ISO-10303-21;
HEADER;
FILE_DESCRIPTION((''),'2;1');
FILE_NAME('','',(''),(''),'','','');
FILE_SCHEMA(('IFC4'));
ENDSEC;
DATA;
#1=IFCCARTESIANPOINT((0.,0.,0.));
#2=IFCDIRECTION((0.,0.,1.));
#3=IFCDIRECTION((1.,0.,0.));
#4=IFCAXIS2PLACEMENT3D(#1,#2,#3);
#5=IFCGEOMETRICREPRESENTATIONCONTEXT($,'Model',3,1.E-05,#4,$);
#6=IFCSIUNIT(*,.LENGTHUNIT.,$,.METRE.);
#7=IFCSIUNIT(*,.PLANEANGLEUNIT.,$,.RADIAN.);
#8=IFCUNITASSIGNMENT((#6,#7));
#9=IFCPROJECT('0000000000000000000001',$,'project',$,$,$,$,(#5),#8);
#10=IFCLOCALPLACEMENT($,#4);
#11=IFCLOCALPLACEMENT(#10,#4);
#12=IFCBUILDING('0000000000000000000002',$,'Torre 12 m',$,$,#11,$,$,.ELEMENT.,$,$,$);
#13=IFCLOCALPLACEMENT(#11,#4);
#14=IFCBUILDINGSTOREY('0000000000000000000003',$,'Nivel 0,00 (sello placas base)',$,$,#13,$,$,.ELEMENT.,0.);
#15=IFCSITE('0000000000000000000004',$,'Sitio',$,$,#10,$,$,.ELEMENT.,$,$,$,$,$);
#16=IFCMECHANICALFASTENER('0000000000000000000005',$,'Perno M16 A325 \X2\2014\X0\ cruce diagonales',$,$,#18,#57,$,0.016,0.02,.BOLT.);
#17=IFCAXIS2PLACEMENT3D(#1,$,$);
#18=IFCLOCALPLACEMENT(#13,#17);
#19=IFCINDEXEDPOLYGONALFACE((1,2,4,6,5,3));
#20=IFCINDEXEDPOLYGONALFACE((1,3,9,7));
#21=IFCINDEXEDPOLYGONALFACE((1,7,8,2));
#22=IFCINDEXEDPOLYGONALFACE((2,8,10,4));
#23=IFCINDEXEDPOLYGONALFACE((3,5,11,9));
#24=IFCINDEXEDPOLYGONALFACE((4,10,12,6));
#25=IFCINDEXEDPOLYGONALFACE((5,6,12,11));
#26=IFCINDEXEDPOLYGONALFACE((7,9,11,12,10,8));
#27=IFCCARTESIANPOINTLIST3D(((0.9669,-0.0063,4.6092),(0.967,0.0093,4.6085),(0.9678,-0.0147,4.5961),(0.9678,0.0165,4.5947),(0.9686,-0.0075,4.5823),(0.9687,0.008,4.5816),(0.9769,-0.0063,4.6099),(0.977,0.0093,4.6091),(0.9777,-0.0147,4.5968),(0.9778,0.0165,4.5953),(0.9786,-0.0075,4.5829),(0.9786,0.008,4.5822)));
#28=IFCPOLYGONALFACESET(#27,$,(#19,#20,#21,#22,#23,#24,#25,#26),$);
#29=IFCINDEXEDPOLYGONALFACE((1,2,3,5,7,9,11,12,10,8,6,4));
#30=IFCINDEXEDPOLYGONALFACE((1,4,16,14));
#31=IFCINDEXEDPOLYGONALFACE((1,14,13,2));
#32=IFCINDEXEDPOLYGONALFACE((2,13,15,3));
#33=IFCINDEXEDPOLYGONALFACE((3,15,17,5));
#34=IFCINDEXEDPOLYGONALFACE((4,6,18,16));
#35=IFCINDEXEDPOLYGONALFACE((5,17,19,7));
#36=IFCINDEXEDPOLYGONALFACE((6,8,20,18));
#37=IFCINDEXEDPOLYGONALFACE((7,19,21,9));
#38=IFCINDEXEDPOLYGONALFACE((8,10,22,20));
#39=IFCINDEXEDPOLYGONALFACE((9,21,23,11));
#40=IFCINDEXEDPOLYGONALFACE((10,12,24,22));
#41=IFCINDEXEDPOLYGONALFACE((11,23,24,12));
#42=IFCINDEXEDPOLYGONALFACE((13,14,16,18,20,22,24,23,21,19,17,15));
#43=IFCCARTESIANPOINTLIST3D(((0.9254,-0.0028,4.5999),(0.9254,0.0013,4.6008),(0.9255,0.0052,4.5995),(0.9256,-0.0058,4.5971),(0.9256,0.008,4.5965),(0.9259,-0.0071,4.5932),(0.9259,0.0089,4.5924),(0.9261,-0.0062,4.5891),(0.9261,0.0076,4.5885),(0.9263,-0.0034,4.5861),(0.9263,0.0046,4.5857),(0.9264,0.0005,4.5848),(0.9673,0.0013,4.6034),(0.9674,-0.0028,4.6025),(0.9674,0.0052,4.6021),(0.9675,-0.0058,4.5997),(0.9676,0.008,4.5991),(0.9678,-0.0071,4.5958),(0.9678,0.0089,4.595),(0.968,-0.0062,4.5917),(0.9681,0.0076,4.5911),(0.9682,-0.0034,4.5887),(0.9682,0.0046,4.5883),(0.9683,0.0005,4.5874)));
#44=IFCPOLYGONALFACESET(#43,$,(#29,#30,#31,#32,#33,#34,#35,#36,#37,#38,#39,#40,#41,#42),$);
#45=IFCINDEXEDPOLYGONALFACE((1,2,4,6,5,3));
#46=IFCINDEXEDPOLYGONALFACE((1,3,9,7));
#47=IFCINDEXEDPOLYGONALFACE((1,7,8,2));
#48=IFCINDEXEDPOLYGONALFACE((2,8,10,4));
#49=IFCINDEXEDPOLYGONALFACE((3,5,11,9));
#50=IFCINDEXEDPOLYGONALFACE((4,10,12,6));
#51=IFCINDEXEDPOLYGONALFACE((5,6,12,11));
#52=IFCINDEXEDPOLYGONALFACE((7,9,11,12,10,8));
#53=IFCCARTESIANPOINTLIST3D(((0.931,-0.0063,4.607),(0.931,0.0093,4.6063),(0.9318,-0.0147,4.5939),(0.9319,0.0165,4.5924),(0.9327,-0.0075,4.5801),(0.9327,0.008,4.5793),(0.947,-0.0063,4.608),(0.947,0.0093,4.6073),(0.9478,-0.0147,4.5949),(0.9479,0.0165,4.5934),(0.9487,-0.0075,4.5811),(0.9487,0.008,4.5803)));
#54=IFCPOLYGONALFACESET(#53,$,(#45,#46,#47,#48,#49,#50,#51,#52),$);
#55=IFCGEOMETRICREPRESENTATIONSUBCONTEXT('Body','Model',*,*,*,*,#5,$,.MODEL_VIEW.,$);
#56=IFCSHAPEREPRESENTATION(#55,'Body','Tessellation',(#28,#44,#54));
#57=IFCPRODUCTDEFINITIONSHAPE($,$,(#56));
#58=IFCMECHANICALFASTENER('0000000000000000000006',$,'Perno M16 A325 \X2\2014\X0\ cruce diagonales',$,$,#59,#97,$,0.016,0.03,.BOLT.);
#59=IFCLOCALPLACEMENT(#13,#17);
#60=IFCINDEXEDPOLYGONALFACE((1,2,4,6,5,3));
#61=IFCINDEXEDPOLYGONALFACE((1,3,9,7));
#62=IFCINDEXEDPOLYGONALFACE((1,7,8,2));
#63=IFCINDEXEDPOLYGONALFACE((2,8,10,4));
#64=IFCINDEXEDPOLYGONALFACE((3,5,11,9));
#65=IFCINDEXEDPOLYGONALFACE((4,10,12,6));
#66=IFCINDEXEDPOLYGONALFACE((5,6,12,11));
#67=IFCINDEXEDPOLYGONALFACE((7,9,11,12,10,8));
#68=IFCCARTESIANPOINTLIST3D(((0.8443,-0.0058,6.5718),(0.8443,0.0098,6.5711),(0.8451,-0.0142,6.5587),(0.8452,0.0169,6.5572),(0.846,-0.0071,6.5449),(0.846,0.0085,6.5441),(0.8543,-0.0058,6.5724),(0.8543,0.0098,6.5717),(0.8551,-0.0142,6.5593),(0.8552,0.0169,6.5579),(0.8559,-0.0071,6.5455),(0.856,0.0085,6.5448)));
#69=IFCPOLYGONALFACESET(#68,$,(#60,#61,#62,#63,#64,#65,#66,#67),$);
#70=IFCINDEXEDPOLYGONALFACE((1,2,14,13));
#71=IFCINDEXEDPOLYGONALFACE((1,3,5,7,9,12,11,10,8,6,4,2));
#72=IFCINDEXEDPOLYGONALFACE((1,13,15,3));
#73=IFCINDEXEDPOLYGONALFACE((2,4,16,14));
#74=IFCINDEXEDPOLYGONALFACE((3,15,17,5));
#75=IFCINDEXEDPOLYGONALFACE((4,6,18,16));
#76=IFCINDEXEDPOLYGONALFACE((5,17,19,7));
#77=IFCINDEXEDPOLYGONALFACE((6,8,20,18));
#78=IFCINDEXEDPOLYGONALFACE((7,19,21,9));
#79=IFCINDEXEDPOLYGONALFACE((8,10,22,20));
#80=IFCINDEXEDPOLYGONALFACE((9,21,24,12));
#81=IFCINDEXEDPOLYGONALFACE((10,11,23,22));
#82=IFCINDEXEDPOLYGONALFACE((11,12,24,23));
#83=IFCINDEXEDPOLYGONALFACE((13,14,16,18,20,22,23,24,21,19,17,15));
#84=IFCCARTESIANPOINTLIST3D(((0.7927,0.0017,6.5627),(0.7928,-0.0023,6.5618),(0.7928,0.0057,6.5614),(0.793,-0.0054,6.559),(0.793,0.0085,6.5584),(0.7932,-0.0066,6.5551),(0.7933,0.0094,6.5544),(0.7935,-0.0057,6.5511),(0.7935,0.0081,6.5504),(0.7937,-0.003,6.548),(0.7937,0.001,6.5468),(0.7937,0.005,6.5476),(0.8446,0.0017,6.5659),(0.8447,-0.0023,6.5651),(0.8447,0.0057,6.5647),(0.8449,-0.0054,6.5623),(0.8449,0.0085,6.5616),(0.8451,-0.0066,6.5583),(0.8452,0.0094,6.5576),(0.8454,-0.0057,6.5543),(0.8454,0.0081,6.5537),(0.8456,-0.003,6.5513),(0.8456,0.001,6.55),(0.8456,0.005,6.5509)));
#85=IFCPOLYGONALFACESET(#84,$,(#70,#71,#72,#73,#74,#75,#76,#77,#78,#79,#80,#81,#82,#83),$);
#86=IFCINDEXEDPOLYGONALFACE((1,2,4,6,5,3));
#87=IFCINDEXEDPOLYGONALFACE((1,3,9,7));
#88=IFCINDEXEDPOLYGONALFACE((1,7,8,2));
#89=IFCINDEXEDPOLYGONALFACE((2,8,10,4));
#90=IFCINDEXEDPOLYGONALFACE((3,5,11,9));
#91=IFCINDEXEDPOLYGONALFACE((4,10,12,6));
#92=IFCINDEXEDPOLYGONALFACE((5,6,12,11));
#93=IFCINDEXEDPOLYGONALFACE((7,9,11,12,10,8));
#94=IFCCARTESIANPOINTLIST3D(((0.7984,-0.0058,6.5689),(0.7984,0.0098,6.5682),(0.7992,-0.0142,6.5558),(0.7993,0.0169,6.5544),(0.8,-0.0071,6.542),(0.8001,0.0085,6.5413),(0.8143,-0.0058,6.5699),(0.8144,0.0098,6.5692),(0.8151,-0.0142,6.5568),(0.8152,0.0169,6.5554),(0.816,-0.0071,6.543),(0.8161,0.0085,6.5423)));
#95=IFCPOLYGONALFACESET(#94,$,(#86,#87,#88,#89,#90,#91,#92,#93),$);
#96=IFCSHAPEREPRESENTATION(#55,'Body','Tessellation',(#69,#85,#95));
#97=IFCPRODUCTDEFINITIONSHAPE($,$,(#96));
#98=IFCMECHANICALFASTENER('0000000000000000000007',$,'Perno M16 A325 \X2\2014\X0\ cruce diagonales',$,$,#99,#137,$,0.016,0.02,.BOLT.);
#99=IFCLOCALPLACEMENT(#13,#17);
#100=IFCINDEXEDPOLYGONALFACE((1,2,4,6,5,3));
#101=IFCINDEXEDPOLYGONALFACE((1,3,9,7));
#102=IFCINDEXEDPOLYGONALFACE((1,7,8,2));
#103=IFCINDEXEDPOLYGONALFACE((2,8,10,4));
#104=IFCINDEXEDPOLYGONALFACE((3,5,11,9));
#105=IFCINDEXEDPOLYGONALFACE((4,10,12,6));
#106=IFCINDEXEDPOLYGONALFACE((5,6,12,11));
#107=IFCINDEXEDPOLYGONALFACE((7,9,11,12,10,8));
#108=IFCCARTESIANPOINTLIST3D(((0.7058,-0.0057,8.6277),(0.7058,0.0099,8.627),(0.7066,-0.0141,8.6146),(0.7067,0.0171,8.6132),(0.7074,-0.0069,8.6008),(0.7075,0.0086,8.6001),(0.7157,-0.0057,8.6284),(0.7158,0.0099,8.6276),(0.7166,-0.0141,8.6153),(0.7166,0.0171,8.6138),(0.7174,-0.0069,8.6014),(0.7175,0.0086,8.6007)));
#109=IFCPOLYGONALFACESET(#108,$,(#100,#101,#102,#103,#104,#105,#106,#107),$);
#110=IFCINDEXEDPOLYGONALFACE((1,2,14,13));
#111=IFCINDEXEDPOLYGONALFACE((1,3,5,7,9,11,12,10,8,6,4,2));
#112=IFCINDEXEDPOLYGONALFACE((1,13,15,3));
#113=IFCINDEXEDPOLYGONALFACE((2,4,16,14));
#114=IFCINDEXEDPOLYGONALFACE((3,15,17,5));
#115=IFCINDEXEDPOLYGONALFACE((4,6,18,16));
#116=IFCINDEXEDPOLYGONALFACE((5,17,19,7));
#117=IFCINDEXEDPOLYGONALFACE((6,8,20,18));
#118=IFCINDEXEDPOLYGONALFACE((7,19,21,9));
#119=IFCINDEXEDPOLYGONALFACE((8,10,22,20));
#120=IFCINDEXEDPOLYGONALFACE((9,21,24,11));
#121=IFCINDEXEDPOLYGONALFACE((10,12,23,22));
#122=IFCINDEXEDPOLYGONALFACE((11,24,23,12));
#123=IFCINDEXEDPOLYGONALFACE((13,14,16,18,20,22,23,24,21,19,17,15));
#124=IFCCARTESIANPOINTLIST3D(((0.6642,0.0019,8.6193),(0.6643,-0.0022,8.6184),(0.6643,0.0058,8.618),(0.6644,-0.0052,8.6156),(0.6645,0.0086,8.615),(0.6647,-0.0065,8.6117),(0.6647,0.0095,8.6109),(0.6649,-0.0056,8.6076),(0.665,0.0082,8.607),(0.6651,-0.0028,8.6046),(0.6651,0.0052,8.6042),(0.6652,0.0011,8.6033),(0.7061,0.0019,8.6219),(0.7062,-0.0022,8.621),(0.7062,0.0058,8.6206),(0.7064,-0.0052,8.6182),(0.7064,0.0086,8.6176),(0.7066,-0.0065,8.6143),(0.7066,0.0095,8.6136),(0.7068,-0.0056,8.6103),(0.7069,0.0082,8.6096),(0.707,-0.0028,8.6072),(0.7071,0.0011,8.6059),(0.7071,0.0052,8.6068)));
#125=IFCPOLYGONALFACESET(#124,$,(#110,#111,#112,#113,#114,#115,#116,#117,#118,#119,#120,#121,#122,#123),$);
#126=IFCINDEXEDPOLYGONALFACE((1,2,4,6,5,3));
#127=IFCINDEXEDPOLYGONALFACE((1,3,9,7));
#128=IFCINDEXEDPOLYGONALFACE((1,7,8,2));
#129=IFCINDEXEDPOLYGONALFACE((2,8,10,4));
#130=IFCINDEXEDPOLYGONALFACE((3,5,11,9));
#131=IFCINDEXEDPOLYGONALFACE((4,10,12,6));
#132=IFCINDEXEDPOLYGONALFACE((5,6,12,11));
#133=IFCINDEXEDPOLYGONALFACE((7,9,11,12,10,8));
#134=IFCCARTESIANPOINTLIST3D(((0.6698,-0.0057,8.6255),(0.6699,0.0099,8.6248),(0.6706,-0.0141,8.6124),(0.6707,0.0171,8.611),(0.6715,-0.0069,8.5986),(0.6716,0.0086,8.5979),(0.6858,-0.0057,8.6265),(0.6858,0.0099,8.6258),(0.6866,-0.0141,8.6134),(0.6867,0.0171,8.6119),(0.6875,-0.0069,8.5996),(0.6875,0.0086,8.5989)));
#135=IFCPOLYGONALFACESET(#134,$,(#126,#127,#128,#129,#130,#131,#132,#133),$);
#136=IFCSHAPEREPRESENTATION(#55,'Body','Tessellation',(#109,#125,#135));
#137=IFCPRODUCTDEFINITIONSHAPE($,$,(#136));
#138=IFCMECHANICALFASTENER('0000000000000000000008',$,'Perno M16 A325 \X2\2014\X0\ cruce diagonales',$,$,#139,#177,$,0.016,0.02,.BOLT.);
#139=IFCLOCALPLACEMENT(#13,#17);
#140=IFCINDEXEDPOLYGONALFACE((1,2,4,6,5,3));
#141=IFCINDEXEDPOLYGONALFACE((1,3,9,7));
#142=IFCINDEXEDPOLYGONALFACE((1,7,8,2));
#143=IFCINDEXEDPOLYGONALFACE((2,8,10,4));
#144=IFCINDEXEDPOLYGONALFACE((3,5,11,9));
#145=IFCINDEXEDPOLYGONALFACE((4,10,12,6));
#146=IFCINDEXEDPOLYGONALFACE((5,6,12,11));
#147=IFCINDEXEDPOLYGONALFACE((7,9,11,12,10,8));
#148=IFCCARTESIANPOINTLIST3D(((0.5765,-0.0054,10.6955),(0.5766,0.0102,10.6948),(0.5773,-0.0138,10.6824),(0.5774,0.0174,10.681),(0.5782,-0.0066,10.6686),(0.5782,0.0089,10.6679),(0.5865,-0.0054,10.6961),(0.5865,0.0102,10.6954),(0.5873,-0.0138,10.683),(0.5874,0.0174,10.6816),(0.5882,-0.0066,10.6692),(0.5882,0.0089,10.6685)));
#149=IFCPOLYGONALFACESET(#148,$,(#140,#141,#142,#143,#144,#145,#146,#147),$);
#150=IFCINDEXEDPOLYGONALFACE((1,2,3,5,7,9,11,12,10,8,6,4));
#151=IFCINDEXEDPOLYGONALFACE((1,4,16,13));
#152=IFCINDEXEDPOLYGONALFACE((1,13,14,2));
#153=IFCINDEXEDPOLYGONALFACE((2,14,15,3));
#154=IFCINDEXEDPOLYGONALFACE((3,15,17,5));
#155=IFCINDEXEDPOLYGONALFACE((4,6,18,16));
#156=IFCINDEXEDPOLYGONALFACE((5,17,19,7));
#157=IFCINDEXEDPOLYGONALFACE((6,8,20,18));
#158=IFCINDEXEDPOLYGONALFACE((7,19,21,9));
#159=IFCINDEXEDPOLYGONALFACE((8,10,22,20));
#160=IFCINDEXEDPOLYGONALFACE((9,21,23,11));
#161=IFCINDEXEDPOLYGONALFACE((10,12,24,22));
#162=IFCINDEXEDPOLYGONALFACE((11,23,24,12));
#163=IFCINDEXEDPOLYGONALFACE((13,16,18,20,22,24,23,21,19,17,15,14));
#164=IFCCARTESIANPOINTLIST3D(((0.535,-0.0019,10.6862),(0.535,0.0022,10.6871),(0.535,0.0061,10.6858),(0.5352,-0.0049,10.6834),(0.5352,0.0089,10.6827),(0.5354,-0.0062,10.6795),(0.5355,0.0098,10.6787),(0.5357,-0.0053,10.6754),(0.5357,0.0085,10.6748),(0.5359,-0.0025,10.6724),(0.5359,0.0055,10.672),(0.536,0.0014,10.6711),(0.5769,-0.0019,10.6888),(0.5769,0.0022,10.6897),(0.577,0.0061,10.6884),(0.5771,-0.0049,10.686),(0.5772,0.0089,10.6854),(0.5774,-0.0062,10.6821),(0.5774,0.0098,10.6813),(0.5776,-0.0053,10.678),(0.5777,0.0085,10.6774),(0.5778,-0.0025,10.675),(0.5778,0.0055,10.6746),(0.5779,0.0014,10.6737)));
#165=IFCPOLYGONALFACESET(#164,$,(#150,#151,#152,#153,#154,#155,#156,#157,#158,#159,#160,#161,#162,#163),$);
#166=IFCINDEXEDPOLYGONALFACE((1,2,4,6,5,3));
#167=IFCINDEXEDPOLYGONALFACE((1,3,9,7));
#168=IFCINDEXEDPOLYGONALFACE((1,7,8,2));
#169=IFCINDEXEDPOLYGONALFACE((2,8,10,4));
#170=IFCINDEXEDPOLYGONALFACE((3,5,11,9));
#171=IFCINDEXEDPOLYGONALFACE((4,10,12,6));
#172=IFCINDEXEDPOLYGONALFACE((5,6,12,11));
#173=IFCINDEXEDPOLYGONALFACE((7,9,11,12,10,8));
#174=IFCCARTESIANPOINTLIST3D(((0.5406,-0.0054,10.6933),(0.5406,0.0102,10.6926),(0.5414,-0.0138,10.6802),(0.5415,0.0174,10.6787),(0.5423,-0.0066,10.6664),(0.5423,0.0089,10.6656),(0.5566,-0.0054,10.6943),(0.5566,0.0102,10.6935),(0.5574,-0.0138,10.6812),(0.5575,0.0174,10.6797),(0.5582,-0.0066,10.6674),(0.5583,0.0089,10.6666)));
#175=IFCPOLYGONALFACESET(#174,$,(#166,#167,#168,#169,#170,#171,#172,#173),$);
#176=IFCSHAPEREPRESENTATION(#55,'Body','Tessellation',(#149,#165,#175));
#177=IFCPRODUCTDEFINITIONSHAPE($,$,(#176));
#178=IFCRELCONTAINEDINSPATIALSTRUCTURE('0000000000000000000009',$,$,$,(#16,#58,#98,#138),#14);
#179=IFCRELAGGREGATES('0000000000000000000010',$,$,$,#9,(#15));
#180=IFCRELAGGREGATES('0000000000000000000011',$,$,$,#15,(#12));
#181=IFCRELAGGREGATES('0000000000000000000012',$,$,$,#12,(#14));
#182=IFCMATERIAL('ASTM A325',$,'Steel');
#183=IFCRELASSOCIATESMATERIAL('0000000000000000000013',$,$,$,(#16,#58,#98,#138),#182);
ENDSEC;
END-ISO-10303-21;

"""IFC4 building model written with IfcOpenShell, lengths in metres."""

from ifc_helpers import new_model, si_unit, frame, origin_with_axes, place, context, subcontext, project, spatial, polyline, outline, extrude, material, element, save


model = new_model("IFC4")

# Units and contexts
model_context = context("Model", 3, precision=1e-05, world=origin_with_axes())
body_context = subcontext(model_context, "Body", "Model", "MODEL_VIEW")
ifc_project = project(units=[si_unit("LENGTHUNIT", "METRE"), si_unit("PLANEANGLEUNIT", "RADIAN")], contexts=[model_context])

# Site, building, storey
site_placement = place(None, origin_with_axes())
site = spatial("IfcSite", under=ifc_project, at=site_placement, Name="Sitio", CompositionType="ELEMENT")
building_placement = place(site_placement, origin_with_axes())
building = spatial("IfcBuilding", under=site, at=building_placement, Name="Torre 12 m", CompositionType="ELEMENT")
storey_placement = place(building_placement, origin_with_axes())
storey = spatial("IfcBuildingStorey", under=building, at=storey_placement, Name="Nivel 0,00 (sello placas base)", CompositionType="ELEMENT", Elevation=0.0)

# Shared definitions
placement = place(storey_placement, origin_with_axes())

# Mechanical fasteners
ifc_material_1 = material(Name="ASTM A325", Category="Steel")
element("IfcMechanicalFastener", 1, at=placement, inside=storey, material=ifc_material_1, Name="Perno M16 A325 — cruce diagonales", NominalDiameter=0.016, NominalLength=0.02, PredefinedType="BOLT", context=body_context, shape_type="SweptSolid", body=[
    extrude(outline(polyline([(0.0135, 0.0078), (0.0, 0.0156), (-0.0135, 0.0078), (-0.0135, -0.0078), (0.0, -0.0156), (0.0135, -0.0078), (0.0135, 0.0078)])), frame((0.9778, 0.0009, 4.596), z_axis=(-0.998053, 0.0, -0.062378), x_axis=(0.033672, 0.841794, -0.538748)), (0.0, 0.0, 1.0), 0.01),
    extrude(outline(polyline([(0.008, 0.0), (0.0069, 0.004), (0.004, 0.0069), (0.0, 0.008), (-0.004, 0.0069), (-0.0069, 0.004), (-0.008, 0.0), (-0.0069, -0.004), (-0.004, -0.0069), (0.0, -0.008), (0.004, -0.0069), (0.0069, -0.004), (0.008, 0.0)])), frame((0.9678, 0.0009, 4.5954), z_axis=(-0.998053, 0.0, -0.062378), x_axis=(0.033672, 0.841794, -0.538748)), (0.0, 0.0, 1.0), 0.042),
    extrude(outline(polyline([(0.0135, 0.0078), (0.0, 0.0156), (-0.0135, 0.0078), (-0.0135, -0.0078), (0.0, -0.0156), (0.0135, -0.0078), (0.0135, 0.0078)])), frame((0.9478, 0.0009, 4.5942), z_axis=(-0.998053, 0.0, -0.062378), x_axis=(0.033672, 0.841794, -0.538748)), (0.0, 0.0, 1.0), 0.016),
])
element("IfcMechanicalFastener", 2, at=placement, inside=storey, material=ifc_material_1, Name="Perno M16 A325 — cruce diagonales", NominalDiameter=0.016, NominalLength=0.03, PredefinedType="BOLT", context=body_context, shape_type="SweptSolid", body=[
    extrude(outline(polyline([(0.0135, 0.0078), (0.0, 0.0156), (-0.0135, 0.0078), (-0.0135, -0.0078), (0.0, -0.0156), (0.0135, -0.0078), (0.0135, 0.0078)])), frame((0.8551, 0.0014, 6.5586), z_axis=(-0.998053, 0.0, -0.062378), x_axis=(0.033672, 0.841794, -0.538748)), (0.0, 0.0, 1.0), 0.01),
    extrude(outline(polyline([(0.008, 0.0), (0.0069, 0.004), (0.004, 0.0069), (0.0, 0.008), (-0.004, 0.0069), (-0.0069, 0.004), (-0.008, 0.0), (-0.0069, -0.004), (-0.004, -0.0069), (0.0, -0.008), (0.004, -0.0069), (0.0069, -0.004), (0.008, 0.0)])), frame((0.8451, 0.0014, 6.558), z_axis=(-0.998053, 0.0, -0.062378), x_axis=(0.033672, 0.841794, -0.538748)), (0.0, 0.0, 1.0), 0.052),
    extrude(outline(polyline([(0.0135, 0.0078), (0.0, 0.0156), (-0.0135, 0.0078), (-0.0135, -0.0078), (0.0, -0.0156), (0.0135, -0.0078), (0.0135, 0.0078)])), frame((0.8152, 0.0014, 6.5561), z_axis=(-0.998053, 0.0, -0.062378), x_axis=(0.033672, 0.841794, -0.538748)), (0.0, 0.0, 1.0), 0.016),
])
element("IfcMechanicalFastener", 3, at=placement, inside=storey, material=ifc_material_1, Name="Perno M16 A325 — cruce diagonales", NominalDiameter=0.016, NominalLength=0.02, PredefinedType="BOLT", context=body_context, shape_type="SweptSolid", body=[
    extrude(outline(polyline([(0.0135, 0.0078), (0.0, 0.0156), (-0.0135, 0.0078), (-0.0135, -0.0078), (0.0, -0.0156), (0.0135, -0.0078), (0.0135, 0.0078)])), frame((0.7166, 0.0015, 8.6145), z_axis=(-0.998053, 0.0, -0.062378), x_axis=(0.033672, 0.841794, -0.538748)), (0.0, 0.0, 1.0), 0.01),
    extrude(outline(polyline([(0.008, 0.0), (0.0069, 0.004), (0.004, 0.0069), (0.0, 0.008), (-0.004, 0.0069), (-0.0069, 0.004), (-0.008, 0.0), (-0.0069, -0.004), (-0.004, -0.0069), (0.0, -0.008), (0.004, -0.0069), (0.0069, -0.004), (0.008, 0.0)])), frame((0.7066, 0.0015, 8.6139), z_axis=(-0.998053, 0.0, -0.062378), x_axis=(0.033672, 0.841794, -0.538748)), (0.0, 0.0, 1.0), 0.042),
    extrude(outline(polyline([(0.0135, 0.0078), (0.0, 0.0156), (-0.0135, 0.0078), (-0.0135, -0.0078), (0.0, -0.0156), (0.0135, -0.0078), (0.0135, 0.0078)])), frame((0.6867, 0.0015, 8.6127), z_axis=(-0.998053, 0.0, -0.062378), x_axis=(0.033672, 0.841794, -0.538748)), (0.0, 0.0, 1.0), 0.016),
])
element("IfcMechanicalFastener", 4, at=placement, inside=storey, material=ifc_material_1, Name="Perno M16 A325 — cruce diagonales", NominalDiameter=0.016, NominalLength=0.02, PredefinedType="BOLT", context=body_context, shape_type="SweptSolid", body=[
    extrude(outline(polyline([(0.0135, 0.0078), (0.0, 0.0156), (-0.0135, 0.0078), (-0.0135, -0.0078), (0.0, -0.0156), (0.0135, -0.0078), (0.0135, 0.0078)])), frame((0.5874, 0.0018, 10.6823), z_axis=(-0.998053, 0.0, -0.062378), x_axis=(0.033672, 0.841794, -0.538748)), (0.0, 0.0, 1.0), 0.01),
    extrude(outline(polyline([(0.008, 0.0), (0.0069, 0.004), (0.004, 0.0069), (0.0, 0.008), (-0.004, 0.0069), (-0.0069, 0.004), (-0.008, 0.0), (-0.0069, -0.004), (-0.004, -0.0069), (0.0, -0.008), (0.004, -0.0069), (0.0069, -0.004), (0.008, 0.0)])), frame((0.5774, 0.0018, 10.6817), z_axis=(-0.998053, 0.0, -0.062378), x_axis=(0.033672, 0.841794, -0.538748)), (0.0, 0.0, 1.0), 0.042),
    extrude(outline(polyline([(0.0135, 0.0078), (0.0, 0.0156), (-0.0135, 0.0078), (-0.0135, -0.0078), (0.0, -0.0156), (0.0135, -0.0078), (0.0135, 0.0078)])), frame((0.5574, 0.0018, 10.6805), z_axis=(-0.998053, 0.0, -0.062378), x_axis=(0.033672, 0.841794, -0.538748)), (0.0, 0.0, 1.0), 0.016),
])

save(model, "model.ifc")
